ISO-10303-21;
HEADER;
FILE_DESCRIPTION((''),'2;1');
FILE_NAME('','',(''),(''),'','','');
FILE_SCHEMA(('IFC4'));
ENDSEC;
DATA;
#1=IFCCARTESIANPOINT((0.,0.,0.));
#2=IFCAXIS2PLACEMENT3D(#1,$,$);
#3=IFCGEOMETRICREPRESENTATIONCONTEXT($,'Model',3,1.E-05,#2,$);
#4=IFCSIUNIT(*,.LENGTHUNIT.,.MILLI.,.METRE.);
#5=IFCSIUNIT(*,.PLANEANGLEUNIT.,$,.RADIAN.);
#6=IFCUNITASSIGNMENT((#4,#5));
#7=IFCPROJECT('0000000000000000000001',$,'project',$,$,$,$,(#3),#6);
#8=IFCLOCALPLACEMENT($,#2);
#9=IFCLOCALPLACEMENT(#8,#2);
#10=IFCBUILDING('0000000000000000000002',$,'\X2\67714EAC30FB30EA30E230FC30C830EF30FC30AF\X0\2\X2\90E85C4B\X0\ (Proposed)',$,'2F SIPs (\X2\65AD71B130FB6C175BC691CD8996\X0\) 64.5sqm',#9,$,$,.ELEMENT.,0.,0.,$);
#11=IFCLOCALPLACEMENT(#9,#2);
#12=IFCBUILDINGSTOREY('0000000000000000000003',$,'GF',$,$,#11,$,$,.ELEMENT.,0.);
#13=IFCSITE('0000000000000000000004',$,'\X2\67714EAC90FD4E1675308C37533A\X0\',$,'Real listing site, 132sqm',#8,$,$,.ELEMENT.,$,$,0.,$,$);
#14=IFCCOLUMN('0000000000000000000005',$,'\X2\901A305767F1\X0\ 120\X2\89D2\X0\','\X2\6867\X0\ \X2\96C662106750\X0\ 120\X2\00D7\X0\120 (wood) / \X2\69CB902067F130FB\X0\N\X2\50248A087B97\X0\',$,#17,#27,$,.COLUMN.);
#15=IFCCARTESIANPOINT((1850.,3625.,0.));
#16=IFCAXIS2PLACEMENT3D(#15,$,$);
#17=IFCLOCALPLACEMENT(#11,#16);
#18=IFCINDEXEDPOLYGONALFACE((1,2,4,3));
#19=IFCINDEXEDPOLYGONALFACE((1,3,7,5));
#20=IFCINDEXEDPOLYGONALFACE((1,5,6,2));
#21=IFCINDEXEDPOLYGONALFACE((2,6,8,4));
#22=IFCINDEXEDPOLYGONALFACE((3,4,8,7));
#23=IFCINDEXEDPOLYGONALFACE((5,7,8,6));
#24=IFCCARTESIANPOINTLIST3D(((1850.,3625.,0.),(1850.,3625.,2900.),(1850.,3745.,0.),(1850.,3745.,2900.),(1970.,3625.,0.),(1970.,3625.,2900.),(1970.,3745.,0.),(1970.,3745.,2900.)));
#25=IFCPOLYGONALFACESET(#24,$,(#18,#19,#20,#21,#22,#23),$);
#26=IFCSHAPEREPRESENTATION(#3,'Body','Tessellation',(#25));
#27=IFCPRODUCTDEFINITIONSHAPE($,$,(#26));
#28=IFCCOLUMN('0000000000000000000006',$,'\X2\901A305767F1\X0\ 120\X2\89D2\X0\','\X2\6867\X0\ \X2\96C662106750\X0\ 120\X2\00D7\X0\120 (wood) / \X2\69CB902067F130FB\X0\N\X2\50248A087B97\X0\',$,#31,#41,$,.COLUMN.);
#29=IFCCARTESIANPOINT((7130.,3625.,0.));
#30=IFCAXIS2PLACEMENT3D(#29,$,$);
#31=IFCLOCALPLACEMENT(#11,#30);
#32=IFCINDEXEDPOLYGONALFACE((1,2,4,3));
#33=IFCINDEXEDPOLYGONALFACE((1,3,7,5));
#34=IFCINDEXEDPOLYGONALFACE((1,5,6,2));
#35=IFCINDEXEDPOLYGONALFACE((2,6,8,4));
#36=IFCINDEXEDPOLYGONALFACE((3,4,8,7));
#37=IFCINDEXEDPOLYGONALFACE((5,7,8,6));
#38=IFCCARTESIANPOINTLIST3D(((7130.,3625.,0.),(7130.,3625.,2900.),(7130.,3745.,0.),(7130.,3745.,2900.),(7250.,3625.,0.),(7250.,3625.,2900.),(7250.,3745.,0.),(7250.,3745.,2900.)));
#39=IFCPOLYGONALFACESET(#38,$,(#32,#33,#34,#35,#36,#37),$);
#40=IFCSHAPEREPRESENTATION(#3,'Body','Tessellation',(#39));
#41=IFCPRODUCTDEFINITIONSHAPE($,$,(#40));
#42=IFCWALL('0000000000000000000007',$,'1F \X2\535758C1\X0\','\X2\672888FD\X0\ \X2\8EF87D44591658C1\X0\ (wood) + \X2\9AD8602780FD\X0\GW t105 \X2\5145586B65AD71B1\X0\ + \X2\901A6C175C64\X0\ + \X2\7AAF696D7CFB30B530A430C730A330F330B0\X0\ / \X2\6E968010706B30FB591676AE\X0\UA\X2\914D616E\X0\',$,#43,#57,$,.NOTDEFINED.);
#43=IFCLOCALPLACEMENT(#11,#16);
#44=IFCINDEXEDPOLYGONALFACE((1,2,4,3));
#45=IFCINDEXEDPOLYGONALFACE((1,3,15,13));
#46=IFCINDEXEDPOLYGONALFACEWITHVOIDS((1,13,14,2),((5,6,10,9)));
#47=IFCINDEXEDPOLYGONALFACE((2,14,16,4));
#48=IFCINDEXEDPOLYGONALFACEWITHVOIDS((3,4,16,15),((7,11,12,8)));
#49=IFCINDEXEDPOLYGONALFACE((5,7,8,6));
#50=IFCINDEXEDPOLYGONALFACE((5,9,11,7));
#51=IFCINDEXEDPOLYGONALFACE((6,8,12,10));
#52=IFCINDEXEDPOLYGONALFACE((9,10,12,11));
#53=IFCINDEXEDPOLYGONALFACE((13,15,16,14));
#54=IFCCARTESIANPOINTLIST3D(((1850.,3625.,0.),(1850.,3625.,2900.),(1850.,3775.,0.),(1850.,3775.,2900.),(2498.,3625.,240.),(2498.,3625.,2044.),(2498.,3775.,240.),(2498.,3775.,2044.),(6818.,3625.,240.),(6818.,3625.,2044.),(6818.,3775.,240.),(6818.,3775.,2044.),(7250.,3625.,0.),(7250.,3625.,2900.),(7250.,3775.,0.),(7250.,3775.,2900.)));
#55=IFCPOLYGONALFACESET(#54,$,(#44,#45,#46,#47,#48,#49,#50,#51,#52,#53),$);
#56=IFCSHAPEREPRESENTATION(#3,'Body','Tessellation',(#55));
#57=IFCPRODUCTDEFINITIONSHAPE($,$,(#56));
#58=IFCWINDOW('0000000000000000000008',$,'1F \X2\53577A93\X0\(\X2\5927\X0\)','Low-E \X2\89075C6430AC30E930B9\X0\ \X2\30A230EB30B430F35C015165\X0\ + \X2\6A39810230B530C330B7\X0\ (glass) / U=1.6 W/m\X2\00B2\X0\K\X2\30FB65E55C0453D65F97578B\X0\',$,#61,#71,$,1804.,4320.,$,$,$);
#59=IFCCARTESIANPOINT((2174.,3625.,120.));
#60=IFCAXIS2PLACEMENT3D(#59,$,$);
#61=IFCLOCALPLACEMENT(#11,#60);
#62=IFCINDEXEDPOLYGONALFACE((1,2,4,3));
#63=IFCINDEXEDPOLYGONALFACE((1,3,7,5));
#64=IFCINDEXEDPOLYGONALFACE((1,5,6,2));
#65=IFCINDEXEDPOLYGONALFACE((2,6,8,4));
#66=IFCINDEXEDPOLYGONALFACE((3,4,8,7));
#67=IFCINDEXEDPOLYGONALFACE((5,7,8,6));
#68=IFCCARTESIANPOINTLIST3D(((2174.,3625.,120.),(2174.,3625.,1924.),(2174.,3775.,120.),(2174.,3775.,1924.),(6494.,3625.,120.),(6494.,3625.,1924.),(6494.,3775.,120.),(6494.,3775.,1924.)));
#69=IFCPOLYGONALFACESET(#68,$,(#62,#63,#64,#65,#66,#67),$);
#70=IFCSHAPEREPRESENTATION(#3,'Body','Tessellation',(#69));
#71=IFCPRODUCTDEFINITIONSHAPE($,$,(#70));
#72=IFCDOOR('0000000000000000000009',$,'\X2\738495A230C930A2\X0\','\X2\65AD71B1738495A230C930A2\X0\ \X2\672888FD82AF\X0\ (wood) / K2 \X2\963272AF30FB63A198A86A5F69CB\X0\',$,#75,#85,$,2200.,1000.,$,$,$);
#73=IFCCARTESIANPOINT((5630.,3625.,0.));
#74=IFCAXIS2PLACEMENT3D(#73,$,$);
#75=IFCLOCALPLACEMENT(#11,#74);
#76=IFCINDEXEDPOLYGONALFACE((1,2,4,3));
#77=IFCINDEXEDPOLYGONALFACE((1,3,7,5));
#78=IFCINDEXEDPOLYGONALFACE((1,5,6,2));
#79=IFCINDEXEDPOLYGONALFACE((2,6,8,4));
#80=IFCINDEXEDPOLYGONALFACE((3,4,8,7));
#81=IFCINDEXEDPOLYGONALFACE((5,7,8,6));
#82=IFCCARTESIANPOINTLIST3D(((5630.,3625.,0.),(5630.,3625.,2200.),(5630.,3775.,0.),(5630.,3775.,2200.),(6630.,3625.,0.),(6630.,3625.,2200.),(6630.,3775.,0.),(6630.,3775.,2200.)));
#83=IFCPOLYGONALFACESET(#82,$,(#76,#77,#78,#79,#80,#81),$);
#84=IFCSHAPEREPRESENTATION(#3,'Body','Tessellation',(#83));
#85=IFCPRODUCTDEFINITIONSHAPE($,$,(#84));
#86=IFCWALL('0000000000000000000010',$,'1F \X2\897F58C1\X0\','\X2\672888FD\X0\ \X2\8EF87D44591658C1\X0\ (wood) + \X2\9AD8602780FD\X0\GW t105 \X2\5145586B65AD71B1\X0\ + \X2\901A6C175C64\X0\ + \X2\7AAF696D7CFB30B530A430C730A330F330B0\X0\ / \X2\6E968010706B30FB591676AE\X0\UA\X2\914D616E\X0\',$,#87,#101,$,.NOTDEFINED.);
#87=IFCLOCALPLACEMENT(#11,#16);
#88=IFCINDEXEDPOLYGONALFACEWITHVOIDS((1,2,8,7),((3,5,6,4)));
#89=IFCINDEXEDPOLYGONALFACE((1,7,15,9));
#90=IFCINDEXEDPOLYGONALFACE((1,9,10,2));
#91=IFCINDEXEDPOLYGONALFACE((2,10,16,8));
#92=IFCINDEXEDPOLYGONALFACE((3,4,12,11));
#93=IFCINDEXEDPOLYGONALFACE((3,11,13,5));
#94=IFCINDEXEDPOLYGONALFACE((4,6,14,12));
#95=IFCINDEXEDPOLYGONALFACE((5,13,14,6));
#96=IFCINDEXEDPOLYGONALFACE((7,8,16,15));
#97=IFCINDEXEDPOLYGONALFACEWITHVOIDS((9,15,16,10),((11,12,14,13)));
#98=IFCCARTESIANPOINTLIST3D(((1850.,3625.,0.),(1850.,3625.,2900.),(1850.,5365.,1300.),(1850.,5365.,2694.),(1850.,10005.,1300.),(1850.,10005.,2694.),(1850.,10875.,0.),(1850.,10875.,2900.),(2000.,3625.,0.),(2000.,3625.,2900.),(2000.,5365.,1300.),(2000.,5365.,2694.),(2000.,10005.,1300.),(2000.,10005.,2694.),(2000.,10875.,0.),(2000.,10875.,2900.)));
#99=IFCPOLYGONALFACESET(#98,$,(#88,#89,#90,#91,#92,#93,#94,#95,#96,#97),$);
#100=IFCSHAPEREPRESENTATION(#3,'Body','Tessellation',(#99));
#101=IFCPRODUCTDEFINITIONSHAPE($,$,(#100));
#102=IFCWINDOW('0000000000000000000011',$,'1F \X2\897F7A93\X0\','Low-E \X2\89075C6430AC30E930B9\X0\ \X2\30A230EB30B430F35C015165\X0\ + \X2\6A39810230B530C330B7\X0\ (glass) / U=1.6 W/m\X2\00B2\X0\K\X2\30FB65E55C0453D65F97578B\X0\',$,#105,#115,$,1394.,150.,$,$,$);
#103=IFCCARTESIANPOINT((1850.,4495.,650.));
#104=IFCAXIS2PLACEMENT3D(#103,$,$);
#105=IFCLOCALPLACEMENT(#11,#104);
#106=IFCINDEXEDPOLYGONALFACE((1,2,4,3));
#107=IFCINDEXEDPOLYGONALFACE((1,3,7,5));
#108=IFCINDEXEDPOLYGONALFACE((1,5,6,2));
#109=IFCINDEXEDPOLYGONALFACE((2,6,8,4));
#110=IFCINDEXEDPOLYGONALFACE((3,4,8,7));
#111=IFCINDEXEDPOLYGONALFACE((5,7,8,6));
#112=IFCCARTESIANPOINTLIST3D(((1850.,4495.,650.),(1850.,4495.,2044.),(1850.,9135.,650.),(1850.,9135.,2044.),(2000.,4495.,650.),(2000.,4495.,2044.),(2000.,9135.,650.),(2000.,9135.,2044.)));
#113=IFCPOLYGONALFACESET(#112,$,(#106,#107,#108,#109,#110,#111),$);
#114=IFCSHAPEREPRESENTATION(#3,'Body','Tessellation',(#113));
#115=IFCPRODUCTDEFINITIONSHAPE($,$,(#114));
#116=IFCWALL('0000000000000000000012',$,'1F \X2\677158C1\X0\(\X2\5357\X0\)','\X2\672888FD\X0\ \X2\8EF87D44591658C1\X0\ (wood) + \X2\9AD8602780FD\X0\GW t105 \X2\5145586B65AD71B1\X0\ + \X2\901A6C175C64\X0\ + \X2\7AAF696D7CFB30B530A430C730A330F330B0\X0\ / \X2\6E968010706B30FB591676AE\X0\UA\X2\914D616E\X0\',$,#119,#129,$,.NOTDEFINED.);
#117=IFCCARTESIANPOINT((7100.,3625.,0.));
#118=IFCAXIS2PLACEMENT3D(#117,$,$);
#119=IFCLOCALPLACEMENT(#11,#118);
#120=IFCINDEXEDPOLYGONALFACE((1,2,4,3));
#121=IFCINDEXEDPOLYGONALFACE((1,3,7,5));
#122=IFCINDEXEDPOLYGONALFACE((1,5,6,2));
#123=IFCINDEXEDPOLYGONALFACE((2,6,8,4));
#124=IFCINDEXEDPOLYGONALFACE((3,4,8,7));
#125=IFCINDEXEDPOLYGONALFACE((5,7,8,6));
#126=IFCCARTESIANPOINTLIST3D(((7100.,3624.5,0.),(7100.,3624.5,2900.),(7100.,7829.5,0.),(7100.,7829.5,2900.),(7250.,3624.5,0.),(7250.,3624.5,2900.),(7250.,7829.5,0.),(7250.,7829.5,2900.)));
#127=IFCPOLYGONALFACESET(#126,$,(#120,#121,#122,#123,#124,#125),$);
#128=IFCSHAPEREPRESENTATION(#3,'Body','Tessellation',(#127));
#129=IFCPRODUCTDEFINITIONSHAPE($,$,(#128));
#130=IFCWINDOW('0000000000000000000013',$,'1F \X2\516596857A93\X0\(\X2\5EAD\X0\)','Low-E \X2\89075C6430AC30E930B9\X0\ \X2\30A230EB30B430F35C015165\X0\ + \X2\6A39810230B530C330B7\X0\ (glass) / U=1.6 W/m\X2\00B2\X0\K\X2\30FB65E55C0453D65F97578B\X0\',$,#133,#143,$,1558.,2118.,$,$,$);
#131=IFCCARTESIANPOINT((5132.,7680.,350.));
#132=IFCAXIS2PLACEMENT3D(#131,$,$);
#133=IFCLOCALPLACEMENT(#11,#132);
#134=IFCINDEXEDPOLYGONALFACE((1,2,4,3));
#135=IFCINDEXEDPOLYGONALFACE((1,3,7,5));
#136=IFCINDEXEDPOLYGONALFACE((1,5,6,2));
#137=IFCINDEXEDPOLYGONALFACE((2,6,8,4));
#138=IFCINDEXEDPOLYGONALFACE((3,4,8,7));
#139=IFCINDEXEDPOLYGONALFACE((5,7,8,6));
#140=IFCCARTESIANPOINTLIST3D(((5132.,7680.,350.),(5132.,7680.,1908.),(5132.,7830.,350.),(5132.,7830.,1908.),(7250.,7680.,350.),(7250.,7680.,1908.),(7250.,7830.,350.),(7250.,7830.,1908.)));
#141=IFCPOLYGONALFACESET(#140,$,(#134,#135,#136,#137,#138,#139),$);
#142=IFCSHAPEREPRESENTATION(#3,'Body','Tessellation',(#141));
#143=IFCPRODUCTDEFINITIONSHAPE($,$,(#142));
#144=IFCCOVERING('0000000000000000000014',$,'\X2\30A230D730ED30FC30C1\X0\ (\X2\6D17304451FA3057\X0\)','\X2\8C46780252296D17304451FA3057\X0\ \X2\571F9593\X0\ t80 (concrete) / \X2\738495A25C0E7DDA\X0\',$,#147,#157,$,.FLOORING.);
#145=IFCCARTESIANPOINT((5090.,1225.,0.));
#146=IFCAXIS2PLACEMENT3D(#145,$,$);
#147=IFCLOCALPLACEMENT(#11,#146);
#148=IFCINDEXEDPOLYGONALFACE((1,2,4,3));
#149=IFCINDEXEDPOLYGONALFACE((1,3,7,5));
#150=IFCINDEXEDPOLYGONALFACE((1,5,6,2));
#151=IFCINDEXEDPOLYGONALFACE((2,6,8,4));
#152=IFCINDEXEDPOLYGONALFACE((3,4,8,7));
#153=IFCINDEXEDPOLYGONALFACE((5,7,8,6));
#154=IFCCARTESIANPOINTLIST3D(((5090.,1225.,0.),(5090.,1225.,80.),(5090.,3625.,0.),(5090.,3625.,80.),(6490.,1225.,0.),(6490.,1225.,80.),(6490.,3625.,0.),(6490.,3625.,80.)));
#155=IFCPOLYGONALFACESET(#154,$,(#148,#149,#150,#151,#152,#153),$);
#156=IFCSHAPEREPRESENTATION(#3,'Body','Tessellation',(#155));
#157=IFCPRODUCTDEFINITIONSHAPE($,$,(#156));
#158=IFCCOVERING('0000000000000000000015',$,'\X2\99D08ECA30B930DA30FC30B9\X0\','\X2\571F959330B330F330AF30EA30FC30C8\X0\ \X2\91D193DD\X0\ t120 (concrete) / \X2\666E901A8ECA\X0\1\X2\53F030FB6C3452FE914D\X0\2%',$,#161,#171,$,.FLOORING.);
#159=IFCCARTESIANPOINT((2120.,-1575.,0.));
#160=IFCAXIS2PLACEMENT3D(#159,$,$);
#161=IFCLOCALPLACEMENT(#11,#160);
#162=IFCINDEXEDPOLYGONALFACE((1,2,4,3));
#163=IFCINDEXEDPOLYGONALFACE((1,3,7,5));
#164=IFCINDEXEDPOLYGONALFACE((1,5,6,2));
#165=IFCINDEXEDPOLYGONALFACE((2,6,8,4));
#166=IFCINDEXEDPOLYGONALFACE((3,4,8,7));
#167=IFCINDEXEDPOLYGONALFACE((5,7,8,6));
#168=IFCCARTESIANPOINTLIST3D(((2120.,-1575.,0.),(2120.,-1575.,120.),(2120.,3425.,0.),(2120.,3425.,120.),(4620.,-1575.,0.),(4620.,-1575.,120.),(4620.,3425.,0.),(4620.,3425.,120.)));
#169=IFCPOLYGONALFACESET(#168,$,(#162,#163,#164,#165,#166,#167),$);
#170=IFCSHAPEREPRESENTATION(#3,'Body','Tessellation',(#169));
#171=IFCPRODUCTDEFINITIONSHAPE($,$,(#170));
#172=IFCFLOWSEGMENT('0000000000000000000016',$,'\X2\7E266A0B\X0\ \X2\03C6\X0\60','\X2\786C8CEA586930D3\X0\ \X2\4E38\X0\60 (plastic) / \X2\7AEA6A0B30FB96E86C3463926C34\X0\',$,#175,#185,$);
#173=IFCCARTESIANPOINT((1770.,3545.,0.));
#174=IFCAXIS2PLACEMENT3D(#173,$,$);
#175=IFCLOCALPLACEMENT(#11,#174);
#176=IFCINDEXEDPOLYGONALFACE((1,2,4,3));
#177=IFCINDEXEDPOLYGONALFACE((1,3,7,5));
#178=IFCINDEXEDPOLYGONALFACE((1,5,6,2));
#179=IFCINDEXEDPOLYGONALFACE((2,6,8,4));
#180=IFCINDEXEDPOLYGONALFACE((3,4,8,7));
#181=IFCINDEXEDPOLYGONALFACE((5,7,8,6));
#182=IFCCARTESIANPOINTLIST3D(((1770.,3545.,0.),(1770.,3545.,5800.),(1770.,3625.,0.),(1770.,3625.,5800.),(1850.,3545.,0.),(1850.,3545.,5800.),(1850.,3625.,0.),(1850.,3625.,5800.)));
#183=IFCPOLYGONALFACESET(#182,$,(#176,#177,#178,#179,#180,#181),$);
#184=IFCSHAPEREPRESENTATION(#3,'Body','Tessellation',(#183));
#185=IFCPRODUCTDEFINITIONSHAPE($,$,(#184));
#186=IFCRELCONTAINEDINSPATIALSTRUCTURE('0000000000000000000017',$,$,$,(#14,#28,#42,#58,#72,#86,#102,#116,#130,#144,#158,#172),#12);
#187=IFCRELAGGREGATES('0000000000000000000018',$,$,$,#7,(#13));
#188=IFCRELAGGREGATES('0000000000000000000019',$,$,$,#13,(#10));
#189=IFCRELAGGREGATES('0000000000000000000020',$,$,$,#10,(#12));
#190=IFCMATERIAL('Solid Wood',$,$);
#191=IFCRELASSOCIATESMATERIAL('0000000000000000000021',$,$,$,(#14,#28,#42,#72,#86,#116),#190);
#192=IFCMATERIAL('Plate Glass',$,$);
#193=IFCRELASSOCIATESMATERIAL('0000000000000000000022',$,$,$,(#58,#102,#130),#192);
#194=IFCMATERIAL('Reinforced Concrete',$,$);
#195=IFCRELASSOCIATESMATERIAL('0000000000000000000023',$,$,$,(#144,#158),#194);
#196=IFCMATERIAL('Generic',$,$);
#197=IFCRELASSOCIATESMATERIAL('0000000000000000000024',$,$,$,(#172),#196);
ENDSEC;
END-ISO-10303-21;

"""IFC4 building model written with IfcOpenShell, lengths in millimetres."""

from ifc_helpers import new_model, si_unit, frame, frame_2d, origin, place, context, project, spatial, rectangle, extrude, material, element, fill, save


model = new_model("IFC4")

# Units and contexts
model_context = context("Model", 3, precision=1e-05, world=origin())
ifc_project = project(units=[si_unit("LENGTHUNIT", "METRE", prefix="MILLI"), si_unit("PLANEANGLEUNIT", "RADIAN")], contexts=[model_context])

# Site, building, storey
site_placement = place(None, origin())
site = spatial("IfcSite", under=ifc_project, at=site_placement, Name="東京都世田谷区", ObjectType="Real listing site, 132sqm", CompositionType="ELEMENT", RefElevation=0.0)
building_placement = place(site_placement, origin())
building = spatial("IfcBuilding", under=site, at=building_placement, Name="東京・リモートワーク2部屋 (Proposed)", ObjectType="2F SIPs (断熱・気密重視) 64.5sqm", CompositionType="ELEMENT", ElevationOfRefHeight=0.0, ElevationOfTerrain=0.0)
storey_placement = place(building_placement, origin())
storey = spatial("IfcBuildingStorey", under=building, at=storey_placement, Name="GF", CompositionType="ELEMENT", Elevation=0.0)

# Columns
ifc_material_1 = material(Name="Solid Wood")
column_1_placement = place(storey_placement, frame((1850.0, 3625.0, 0.0)))
element("IfcColumn", 1, at=column_1_placement, inside=storey, material=ifc_material_1, Name="通し柱 120角", Description="桧 集成材 120×120 (wood) / 構造柱・N値計算", PredefinedType="COLUMN", context=model_context, shape_type="SweptSolid", body=[
    extrude(rectangle(XDim=120.0, YDim=120.0, at=frame_2d((60.0, 60.0))), frame((1850.0, 3625.0, 0.0)), (0.0, 0.0, 1.0), 2900.0),
])
column_2_placement = place(storey_placement, frame((7130.0, 3625.0, 0.0)))
element("IfcColumn", 2, at=column_2_placement, inside=storey, material=ifc_material_1, Name="通し柱 120角", Description="桧 集成材 120×120 (wood) / 構造柱・N値計算", PredefinedType="COLUMN", context=model_context, shape_type="SweptSolid", body=[
    extrude(rectangle(XDim=120.0, YDim=120.0, at=frame_2d((60.0, 60.0))), frame((7130.0, 3625.0, 0.0)), (0.0, 0.0, 1.0), 2900.0),
])

# Shared definitions
ifc_material_2 = material(Name="Reinforced Concrete")

# Wall, openings, window, door
wall_1_placement = place(storey_placement, frame((1850.0, 3625.0, 0.0)))
wall_1 = element("IfcWall", 3, at=wall_1_placement, inside=storey, material=ifc_material_1, Name="1F 南壁", Description="木製 軸組外壁 (wood) + 高性能GW t105 充填断熱 + 通気層 + 窯業系サイディング / 準耐火・外皮UA配慮", PredefinedType="NOTDEFINED", context=model_context, shape_type="SweptSolid", body=[
    extrude(rectangle(XDim=5400.0, YDim=150.0, at=frame_2d((2700.0, 75.0))), frame((1850.0, 3625.0, 0.0)), (0.0, 0.0, 1.0), 2900.0),
])
opening_1_placement = place(storey_placement, frame((2174.0, 3625.0, 120.0)))
opening_1 = element("IfcOpeningElement", 4, at=opening_1_placement, cuts=wall_1, PredefinedType="NOTDEFINED", context=model_context, shape_type="SweptSolid", body=[
    extrude(rectangle(XDim=4320.0, YDim=150.0, at=frame_2d((2160.0, 75.0))), frame((2174.0, 3625.0, 120.0)), (0.0, 0.0, 1.0), 1804.0),
])
opening_2_placement = place(storey_placement, frame((5630.0, 3625.0, 0.0)))
opening_2 = element("IfcOpeningElement", 5, at=opening_2_placement, cuts=wall_1, PredefinedType="NOTDEFINED", context=model_context, shape_type="SweptSolid", body=[
    extrude(rectangle(XDim=1000.0, YDim=150.0, at=frame_2d((500.0, 75.0))), frame((5630.0, 3625.0, 0.0)), (0.0, 0.0, 1.0), 2200.0),
])
ifc_material_3 = material(Name="Plate Glass")
window_1_placement = place(storey_placement, frame((2174.0, 3625.0, 120.0)))
window_1 = element("IfcWindow", 6, at=window_1_placement, inside=storey, material=ifc_material_3, Name="1F 南窓(大)", Description="Low-E 複層ガラス アルゴン封入 + 樹脂サッシ (glass) / U=1.6 W/m²K・日射取得型", OverallHeight=1804.0, OverallWidth=4320.0, context=model_context, shape_type="SweptSolid", body=[
    extrude(rectangle(XDim=4320.0, YDim=150.0, at=frame_2d((2160.0, 75.0))), frame((2174.0, 3625.0, 120.0)), (0.0, 0.0, 1.0), 1804.0),
])
fill(opening_1, window_1)
door_1_placement = place(storey_placement, frame((5630.0, 3625.0, 0.0)))
door_1 = element("IfcDoor", 7, at=door_1_placement, inside=storey, material=ifc_material_1, Name="玄関ドア", Description="断熱玄関ドア 木製芯 (wood) / K2 防犯・採風機構", OverallHeight=2200.0, OverallWidth=1000.0, context=model_context, shape_type="SweptSolid", body=[
    extrude(rectangle(XDim=1000.0, YDim=150.0, at=frame_2d((500.0, 75.0))), frame((5630.0, 3625.0, 0.0)), (0.0, 0.0, 1.0), 2200.0),
])
fill(opening_2, door_1)

# Walls, openings, windows
wall_2_placement = place(storey_placement, frame((1850.0, 3625.0, 0.0)))
wall_2 = element("IfcWall", 8, at=wall_2_placement, inside=storey, material=ifc_material_1, Name="1F 西壁", Description="木製 軸組外壁 (wood) + 高性能GW t105 充填断熱 + 通気層 + 窯業系サイディング / 準耐火・外皮UA配慮", PredefinedType="NOTDEFINED", context=model_context, shape_type="SweptSolid", body=[
    extrude(rectangle(XDim=150.0, YDim=7250.0, at=frame_2d((75.0, 3625.0))), frame((1850.0, 3625.0, 0.0)), (0.0, 0.0, 1.0), 2900.0),
])
opening_3_placement = place(storey_placement, frame((1850.0, 4495.0, 650.0)))
opening_3 = element("IfcOpeningElement", 9, at=opening_3_placement, cuts=wall_2, PredefinedType="NOTDEFINED", context=model_context, shape_type="SweptSolid", body=[
    extrude(rectangle(XDim=150.0, YDim=4640.0, at=frame_2d((75.0, 2320.0))), frame((1850.0, 4495.0, 650.0)), (0.0, 0.0, 1.0), 1394.0),
])
window_2_placement = place(storey_placement, frame((1850.0, 4495.0, 650.0)))
window_2 = element("IfcWindow", 10, at=window_2_placement, inside=storey, material=ifc_material_3, Name="1F 西窓", Description="Low-E 複層ガラス アルゴン封入 + 樹脂サッシ (glass) / U=1.6 W/m²K・日射取得型", OverallHeight=1394.0, OverallWidth=150.0, context=model_context, shape_type="SweptSolid", body=[
    extrude(rectangle(XDim=150.0, YDim=4640.0, at=frame_2d((75.0, 2320.0))), frame((1850.0, 4495.0, 650.0)), (0.0, 0.0, 1.0), 1394.0),
])
fill(opening_3, window_2)
wall_3_placement = place(storey_placement, frame((7100.0, 3625.0, 0.0)))
wall_3 = element("IfcWall", 11, at=wall_3_placement, inside=storey, material=ifc_material_1, Name="1F 東壁(南)", Description="木製 軸組外壁 (wood) + 高性能GW t105 充填断熱 + 通気層 + 窯業系サイディング / 準耐火・外皮UA配慮", PredefinedType="NOTDEFINED", context=model_context, shape_type="SweptSolid", body=[
    extrude(rectangle(XDim=150.0, YDim=4205.0, at=frame_2d((75.0, 2102.0))), frame((7100.0, 3625.0, 0.0)), (0.0, 0.0, 1.0), 2900.0),
])
opening_4_placement = place(storey_placement, frame((5132.0, 7680.0, 350.0)))
opening_4 = element("IfcOpeningElement", 12, at=opening_4_placement, cuts=wall_3, PredefinedType="NOTDEFINED", context=model_context, shape_type="SweptSolid", body=[
    extrude(rectangle(XDim=2118.0, YDim=150.0, at=frame_2d((1059.0, 75.0))), frame((5132.0, 7680.0, 350.0)), (0.0, 0.0, 1.0), 1558.0),
])
window_3_placement = place(storey_placement, frame((5132.0, 7680.0, 350.0)))
window_3 = element("IfcWindow", 13, at=window_3_placement, inside=storey, material=ifc_material_3, Name="1F 入隅窓(庭)", Description="Low-E 複層ガラス アルゴン封入 + 樹脂サッシ (glass) / U=1.6 W/m²K・日射取得型", OverallHeight=1558.0, OverallWidth=2118.0, context=model_context, shape_type="SweptSolid", body=[
    extrude(rectangle(XDim=2118.0, YDim=150.0, at=frame_2d((1059.0, 75.0))), frame((5132.0, 7680.0, 350.0)), (0.0, 0.0, 1.0), 1558.0),
])
fill(opening_4, window_3)

# Coverings
covering_1_placement = place(storey_placement, frame((5090.0, 1225.0, 0.0)))
element("IfcCovering", 14, at=covering_1_placement, inside=storey, material=ifc_material_2, Name="アプローチ (洗い出し)", Description="豆砂利洗い出し 土間 t80 (concrete) / 玄関導線", PredefinedType="FLOORING", context=model_context, shape_type="SweptSolid", body=[
    extrude(rectangle(XDim=1400.0, YDim=2400.0, at=frame_2d((700.0, 1200.0))), frame((5090.0, 1225.0, 0.0)), (0.0, 0.0, 1.0), 80.0),
])
covering_2_placement = place(storey_placement, frame((2120.0, -1575.0, 0.0)))
element("IfcCovering", 15, at=covering_2_placement, inside=storey, material=ifc_material_2, Name="駐車スペース", Description="土間コンクリート 金鏝 t120 (concrete) / 普通車1台・水勾配2%", PredefinedType="FLOORING", context=model_context, shape_type="SweptSolid", body=[
    extrude(rectangle(XDim=2500.0, YDim=5000.0, at=frame_2d((1250.0, 2500.0))), frame((2120.0, -1575.0, 0.0)), (0.0, 0.0, 1.0), 120.0),
])

# Flow segment
ifc_material_4 = material(Name="Generic")
flow_segment_1_placement = place(storey_placement, frame((1770.0, 3545.0, 0.0)))
element("IfcFlowSegment", 16, at=flow_segment_1_placement, inside=storey, material=ifc_material_4, Name="縦樋 φ60", Description="硬質塩ビ 丸60 (plastic) / 竪樋・雨水排水", context=model_context, shape_type="SweptSolid", body=[
    extrude(rectangle(XDim=80.0, YDim=80.0, at=frame_2d((40.0, 40.0))), frame((1770.0, 3545.0, 0.0)), (0.0, 0.0, 1.0), 5800.0),
])

save(model, "model.ifc")
